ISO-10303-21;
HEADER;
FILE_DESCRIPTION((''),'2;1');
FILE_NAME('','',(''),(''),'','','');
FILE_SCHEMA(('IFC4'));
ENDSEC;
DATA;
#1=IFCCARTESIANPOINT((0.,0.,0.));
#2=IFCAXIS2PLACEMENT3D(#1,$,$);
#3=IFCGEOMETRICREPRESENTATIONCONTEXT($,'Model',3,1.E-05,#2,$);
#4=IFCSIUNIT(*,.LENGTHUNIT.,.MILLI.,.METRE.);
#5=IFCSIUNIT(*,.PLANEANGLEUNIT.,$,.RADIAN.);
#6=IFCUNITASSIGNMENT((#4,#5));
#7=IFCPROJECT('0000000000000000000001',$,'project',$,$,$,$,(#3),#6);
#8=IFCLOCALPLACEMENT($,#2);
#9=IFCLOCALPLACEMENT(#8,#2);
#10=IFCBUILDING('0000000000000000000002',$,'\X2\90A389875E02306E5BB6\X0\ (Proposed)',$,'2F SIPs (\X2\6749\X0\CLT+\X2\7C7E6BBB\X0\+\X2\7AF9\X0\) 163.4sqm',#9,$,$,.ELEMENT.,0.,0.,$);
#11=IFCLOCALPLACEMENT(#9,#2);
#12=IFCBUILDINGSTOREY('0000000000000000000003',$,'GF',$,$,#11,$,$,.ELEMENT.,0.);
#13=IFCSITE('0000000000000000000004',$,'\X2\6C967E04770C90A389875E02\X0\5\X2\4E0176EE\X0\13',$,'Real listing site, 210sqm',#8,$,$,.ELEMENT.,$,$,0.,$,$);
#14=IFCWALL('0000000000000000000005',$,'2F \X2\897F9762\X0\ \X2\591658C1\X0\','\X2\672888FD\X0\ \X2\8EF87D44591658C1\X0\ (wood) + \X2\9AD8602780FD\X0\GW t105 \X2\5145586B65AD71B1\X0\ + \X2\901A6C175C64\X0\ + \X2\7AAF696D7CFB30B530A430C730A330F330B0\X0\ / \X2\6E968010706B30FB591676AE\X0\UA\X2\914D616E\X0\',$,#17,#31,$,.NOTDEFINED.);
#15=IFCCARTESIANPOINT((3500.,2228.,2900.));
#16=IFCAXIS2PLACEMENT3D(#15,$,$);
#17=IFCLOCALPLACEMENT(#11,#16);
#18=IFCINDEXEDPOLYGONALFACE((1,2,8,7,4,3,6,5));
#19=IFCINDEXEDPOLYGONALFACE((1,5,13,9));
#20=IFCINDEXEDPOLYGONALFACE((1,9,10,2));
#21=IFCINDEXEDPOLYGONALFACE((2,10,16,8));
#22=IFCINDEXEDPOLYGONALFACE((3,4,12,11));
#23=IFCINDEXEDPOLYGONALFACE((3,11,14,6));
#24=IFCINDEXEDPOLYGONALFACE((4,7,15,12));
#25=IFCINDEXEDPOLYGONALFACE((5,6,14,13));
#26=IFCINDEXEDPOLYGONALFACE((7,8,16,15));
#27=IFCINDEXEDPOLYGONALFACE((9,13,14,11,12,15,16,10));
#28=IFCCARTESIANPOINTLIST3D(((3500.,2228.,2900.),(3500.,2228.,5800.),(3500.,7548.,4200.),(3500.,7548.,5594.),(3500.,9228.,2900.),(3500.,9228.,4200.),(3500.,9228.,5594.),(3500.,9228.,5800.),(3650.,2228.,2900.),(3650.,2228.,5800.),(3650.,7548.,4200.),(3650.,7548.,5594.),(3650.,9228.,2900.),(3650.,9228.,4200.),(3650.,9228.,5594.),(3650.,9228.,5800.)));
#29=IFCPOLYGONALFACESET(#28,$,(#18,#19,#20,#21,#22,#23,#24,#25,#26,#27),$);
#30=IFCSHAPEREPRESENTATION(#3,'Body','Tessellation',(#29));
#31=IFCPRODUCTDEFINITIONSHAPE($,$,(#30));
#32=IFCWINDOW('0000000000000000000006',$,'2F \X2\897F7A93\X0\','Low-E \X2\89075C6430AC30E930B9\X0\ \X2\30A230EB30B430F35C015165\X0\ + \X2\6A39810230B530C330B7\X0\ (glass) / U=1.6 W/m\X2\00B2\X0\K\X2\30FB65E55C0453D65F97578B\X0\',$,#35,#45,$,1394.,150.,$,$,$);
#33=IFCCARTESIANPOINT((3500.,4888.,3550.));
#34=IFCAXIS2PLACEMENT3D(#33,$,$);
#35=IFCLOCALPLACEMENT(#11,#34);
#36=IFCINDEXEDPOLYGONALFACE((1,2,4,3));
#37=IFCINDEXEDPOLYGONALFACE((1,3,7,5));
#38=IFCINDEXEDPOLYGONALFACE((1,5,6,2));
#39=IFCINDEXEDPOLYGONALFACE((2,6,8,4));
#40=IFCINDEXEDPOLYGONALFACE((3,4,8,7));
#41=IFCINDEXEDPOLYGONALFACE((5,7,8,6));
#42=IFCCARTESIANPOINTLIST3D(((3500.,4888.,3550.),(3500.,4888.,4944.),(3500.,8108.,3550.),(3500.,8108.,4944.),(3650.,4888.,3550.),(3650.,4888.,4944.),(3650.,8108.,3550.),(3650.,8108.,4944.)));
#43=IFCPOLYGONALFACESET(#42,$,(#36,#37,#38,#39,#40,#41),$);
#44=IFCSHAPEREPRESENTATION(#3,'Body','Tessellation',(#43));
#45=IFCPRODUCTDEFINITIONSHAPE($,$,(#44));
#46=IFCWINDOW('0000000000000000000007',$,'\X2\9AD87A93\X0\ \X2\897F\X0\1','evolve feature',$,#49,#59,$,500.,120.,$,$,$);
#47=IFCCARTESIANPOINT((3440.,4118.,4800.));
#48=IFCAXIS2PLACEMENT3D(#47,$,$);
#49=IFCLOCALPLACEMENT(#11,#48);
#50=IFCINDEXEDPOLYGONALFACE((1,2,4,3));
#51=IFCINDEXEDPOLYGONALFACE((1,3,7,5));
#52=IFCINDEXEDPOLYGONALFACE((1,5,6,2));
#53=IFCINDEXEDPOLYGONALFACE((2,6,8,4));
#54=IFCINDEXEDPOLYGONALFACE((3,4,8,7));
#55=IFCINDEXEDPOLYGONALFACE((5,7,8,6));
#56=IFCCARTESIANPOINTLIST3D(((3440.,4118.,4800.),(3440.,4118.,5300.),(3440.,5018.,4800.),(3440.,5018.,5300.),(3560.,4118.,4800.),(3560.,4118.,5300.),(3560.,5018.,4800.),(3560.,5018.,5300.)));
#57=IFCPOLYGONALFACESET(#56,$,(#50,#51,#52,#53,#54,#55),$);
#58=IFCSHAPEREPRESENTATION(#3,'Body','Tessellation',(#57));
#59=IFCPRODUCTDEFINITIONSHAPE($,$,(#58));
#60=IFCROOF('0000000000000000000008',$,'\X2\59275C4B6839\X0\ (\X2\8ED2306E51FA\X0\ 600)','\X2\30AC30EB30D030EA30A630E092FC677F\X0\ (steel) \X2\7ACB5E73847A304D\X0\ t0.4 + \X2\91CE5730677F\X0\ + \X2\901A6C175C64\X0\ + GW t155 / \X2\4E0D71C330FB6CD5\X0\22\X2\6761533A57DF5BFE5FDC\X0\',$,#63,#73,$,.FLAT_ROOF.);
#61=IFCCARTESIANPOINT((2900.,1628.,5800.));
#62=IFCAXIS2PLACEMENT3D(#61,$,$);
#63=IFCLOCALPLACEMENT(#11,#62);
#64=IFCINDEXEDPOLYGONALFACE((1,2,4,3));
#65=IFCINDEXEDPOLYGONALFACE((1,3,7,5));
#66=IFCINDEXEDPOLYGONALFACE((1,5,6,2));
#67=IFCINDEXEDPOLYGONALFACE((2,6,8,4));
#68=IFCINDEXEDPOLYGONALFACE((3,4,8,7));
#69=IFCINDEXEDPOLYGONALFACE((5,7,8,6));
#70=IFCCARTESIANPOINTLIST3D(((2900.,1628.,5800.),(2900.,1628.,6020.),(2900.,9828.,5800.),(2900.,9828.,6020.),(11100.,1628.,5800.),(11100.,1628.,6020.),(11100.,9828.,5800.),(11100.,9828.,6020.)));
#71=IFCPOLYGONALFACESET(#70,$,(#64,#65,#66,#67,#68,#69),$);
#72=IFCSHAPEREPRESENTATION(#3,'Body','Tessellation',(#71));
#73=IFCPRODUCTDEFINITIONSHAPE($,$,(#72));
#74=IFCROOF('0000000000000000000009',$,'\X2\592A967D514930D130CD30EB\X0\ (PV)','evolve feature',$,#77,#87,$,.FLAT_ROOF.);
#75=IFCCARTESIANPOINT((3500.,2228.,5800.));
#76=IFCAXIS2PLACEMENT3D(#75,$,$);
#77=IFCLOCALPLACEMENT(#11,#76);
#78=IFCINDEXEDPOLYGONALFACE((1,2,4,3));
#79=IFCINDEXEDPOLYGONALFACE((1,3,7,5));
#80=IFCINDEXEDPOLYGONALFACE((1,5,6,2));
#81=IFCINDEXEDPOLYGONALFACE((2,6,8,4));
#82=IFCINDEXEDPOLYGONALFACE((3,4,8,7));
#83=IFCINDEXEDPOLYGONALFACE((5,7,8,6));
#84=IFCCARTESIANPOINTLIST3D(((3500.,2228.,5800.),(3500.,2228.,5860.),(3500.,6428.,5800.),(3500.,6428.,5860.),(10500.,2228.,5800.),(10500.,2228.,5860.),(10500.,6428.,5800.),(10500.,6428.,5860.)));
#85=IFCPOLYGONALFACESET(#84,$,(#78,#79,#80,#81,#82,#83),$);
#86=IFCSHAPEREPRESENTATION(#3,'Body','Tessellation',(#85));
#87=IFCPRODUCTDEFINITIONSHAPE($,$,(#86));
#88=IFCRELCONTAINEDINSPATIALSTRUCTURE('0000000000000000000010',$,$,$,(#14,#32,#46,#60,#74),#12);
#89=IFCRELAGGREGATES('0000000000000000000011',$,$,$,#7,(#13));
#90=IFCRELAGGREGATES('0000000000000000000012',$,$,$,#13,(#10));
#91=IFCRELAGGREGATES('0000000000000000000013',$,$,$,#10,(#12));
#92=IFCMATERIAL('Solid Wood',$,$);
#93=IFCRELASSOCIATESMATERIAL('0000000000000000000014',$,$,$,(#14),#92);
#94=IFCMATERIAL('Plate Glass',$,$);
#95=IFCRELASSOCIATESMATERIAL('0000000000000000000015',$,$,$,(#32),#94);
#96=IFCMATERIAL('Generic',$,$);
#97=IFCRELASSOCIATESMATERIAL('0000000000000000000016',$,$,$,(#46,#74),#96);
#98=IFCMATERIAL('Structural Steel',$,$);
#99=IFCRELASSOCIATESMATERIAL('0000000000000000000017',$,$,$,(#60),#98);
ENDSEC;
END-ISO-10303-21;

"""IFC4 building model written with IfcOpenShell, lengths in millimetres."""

from ifc_helpers import new_model, si_unit, frame, frame_2d, origin, place, context, project, spatial, rectangle, extrude, material, element, fill, save


model = new_model("IFC4")

# Units and contexts
model_context = context("Model", 3, precision=1e-05, world=origin())
ifc_project = project(units=[si_unit("LENGTHUNIT", "METRE", prefix="MILLI"), si_unit("PLANEANGLEUNIT", "RADIAN")], contexts=[model_context])

# Site, building, storey
site_placement = place(None, origin())
site = spatial("IfcSite", under=ifc_project, at=site_placement, Name="沖縄県那覇市5丁目13", ObjectType="Real listing site, 210sqm", CompositionType="ELEMENT", RefElevation=0.0)
building_placement = place(site_placement, origin())
building = spatial("IfcBuilding", under=site, at=building_placement, Name="那覇市の家 (Proposed)", ObjectType="2F SIPs (杉CLT+籾殻+竹) 163.4sqm", CompositionType="ELEMENT", ElevationOfRefHeight=0.0, ElevationOfTerrain=0.0)
storey_placement = place(building_placement, origin())
storey = spatial("IfcBuildingStorey", under=building, at=storey_placement, Name="GF", CompositionType="ELEMENT", Elevation=0.0)

# Shared definitions
ifc_material_1 = material(Name="Solid Wood")
ifc_material_2 = material(Name="Generic")

# Shared definitions
ifc_material_3 = material(Name="Plate Glass")

# Wall, openings, windows
wall_1_placement = place(storey_placement, frame((3500.0, 2228.0, 2900.0)))
wall_1 = element("IfcWall", 1, at=wall_1_placement, inside=storey, material=ifc_material_1, Name="2F 西面 外壁", Description="木製 軸組外壁 (wood) + 高性能GW t105 充填断熱 + 通気層 + 窯業系サイディング / 準耐火・外皮UA配慮", PredefinedType="NOTDEFINED", context=model_context, shape_type="SweptSolid", body=[
    extrude(rectangle(XDim=150.0, YDim=7000.0, at=frame_2d((75.0, 3500.0))), frame((3500.0, 2228.0, 2900.0)), (0.0, 0.0, 1.0), 2900.0),
])
opening_1_placement = place(storey_placement, frame((3500.0, 4888.0, 3550.0)))
opening_1 = element("IfcOpeningElement", 2, at=opening_1_placement, cuts=wall_1, PredefinedType="NOTDEFINED", context=model_context, shape_type="SweptSolid", body=[
    extrude(rectangle(XDim=150.0, YDim=3220.0, at=frame_2d((75.0, 1610.0))), frame((3500.0, 4888.0, 3550.0)), (0.0, 0.0, 1.0), 1394.0),
])
opening_2_placement = place(storey_placement, frame((3440.0, 4118.0, 4800.0)))
opening_2 = element("IfcOpeningElement", 3, at=opening_2_placement, cuts=wall_1, PredefinedType="NOTDEFINED", context=model_context, shape_type="SweptSolid", body=[
    extrude(rectangle(XDim=120.0, YDim=900.0, at=frame_2d((60.0, 450.0))), frame((3440.0, 4118.0, 4800.0)), (0.0, 0.0, 1.0), 500.0),
])
window_1_placement = place(storey_placement, frame((3500.0, 4888.0, 3550.0)))
window_1 = element("IfcWindow", 4, at=window_1_placement, inside=storey, material=ifc_material_3, Name="2F 西窓", Description="Low-E 複層ガラス アルゴン封入 + 樹脂サッシ (glass) / U=1.6 W/m²K・日射取得型", OverallHeight=1394.0, OverallWidth=150.0, context=model_context, shape_type="SweptSolid", body=[
    extrude(rectangle(XDim=150.0, YDim=3220.0, at=frame_2d((75.0, 1610.0))), frame((3500.0, 4888.0, 3550.0)), (0.0, 0.0, 1.0), 1394.0),
])
fill(opening_1, window_1)
window_2_placement = place(storey_placement, frame((3440.0, 4118.0, 4800.0)))
window_2 = element("IfcWindow", 5, at=window_2_placement, inside=storey, material=ifc_material_2, Name="高窓 西1", Description="evolve feature", OverallHeight=500.0, OverallWidth=120.0, context=model_context, shape_type="SweptSolid", body=[
    extrude(rectangle(XDim=120.0, YDim=900.0, at=frame_2d((60.0, 450.0))), frame((3440.0, 4118.0, 4800.0)), (0.0, 0.0, 1.0), 500.0),
])
fill(opening_2, window_2)

# Roofs
ifc_material_4 = material(Name="Structural Steel")
roof_1_placement = place(storey_placement, frame((2900.0, 1628.0, 5800.0)))
element("IfcRoof", 6, at=roof_1_placement, inside=storey, material=ifc_material_4, Name="大屋根 (軒の出 600)", Description="ガルバリウム鋼板 (steel) 立平葺き t0.4 + 野地板 + 通気層 + GW t155 / 不燃・法22条区域対応", PredefinedType="FLAT_ROOF", context=model_context, shape_type="SweptSolid", body=[
    extrude(rectangle(XDim=8200.0, YDim=8200.0, at=frame_2d((4100.0, 4100.0))), frame((2900.0, 1628.0, 5800.0)), (0.0, 0.0, 1.0), 220.0),
])
roof_2_placement = place(storey_placement, frame((3500.0, 2228.0, 5800.0)))
element("IfcRoof", 7, at=roof_2_placement, inside=storey, material=ifc_material_2, Name="太陽光パネル (PV)", Description="evolve feature", PredefinedType="FLAT_ROOF", context=model_context, shape_type="SweptSolid", body=[
    extrude(rectangle(XDim=7000.0, YDim=4200.0, at=frame_2d((3500.0, 2100.0))), frame((3500.0, 2228.0, 5800.0)), (0.0, 0.0, 1.0), 60.0),
])

save(model, "model.ifc")
